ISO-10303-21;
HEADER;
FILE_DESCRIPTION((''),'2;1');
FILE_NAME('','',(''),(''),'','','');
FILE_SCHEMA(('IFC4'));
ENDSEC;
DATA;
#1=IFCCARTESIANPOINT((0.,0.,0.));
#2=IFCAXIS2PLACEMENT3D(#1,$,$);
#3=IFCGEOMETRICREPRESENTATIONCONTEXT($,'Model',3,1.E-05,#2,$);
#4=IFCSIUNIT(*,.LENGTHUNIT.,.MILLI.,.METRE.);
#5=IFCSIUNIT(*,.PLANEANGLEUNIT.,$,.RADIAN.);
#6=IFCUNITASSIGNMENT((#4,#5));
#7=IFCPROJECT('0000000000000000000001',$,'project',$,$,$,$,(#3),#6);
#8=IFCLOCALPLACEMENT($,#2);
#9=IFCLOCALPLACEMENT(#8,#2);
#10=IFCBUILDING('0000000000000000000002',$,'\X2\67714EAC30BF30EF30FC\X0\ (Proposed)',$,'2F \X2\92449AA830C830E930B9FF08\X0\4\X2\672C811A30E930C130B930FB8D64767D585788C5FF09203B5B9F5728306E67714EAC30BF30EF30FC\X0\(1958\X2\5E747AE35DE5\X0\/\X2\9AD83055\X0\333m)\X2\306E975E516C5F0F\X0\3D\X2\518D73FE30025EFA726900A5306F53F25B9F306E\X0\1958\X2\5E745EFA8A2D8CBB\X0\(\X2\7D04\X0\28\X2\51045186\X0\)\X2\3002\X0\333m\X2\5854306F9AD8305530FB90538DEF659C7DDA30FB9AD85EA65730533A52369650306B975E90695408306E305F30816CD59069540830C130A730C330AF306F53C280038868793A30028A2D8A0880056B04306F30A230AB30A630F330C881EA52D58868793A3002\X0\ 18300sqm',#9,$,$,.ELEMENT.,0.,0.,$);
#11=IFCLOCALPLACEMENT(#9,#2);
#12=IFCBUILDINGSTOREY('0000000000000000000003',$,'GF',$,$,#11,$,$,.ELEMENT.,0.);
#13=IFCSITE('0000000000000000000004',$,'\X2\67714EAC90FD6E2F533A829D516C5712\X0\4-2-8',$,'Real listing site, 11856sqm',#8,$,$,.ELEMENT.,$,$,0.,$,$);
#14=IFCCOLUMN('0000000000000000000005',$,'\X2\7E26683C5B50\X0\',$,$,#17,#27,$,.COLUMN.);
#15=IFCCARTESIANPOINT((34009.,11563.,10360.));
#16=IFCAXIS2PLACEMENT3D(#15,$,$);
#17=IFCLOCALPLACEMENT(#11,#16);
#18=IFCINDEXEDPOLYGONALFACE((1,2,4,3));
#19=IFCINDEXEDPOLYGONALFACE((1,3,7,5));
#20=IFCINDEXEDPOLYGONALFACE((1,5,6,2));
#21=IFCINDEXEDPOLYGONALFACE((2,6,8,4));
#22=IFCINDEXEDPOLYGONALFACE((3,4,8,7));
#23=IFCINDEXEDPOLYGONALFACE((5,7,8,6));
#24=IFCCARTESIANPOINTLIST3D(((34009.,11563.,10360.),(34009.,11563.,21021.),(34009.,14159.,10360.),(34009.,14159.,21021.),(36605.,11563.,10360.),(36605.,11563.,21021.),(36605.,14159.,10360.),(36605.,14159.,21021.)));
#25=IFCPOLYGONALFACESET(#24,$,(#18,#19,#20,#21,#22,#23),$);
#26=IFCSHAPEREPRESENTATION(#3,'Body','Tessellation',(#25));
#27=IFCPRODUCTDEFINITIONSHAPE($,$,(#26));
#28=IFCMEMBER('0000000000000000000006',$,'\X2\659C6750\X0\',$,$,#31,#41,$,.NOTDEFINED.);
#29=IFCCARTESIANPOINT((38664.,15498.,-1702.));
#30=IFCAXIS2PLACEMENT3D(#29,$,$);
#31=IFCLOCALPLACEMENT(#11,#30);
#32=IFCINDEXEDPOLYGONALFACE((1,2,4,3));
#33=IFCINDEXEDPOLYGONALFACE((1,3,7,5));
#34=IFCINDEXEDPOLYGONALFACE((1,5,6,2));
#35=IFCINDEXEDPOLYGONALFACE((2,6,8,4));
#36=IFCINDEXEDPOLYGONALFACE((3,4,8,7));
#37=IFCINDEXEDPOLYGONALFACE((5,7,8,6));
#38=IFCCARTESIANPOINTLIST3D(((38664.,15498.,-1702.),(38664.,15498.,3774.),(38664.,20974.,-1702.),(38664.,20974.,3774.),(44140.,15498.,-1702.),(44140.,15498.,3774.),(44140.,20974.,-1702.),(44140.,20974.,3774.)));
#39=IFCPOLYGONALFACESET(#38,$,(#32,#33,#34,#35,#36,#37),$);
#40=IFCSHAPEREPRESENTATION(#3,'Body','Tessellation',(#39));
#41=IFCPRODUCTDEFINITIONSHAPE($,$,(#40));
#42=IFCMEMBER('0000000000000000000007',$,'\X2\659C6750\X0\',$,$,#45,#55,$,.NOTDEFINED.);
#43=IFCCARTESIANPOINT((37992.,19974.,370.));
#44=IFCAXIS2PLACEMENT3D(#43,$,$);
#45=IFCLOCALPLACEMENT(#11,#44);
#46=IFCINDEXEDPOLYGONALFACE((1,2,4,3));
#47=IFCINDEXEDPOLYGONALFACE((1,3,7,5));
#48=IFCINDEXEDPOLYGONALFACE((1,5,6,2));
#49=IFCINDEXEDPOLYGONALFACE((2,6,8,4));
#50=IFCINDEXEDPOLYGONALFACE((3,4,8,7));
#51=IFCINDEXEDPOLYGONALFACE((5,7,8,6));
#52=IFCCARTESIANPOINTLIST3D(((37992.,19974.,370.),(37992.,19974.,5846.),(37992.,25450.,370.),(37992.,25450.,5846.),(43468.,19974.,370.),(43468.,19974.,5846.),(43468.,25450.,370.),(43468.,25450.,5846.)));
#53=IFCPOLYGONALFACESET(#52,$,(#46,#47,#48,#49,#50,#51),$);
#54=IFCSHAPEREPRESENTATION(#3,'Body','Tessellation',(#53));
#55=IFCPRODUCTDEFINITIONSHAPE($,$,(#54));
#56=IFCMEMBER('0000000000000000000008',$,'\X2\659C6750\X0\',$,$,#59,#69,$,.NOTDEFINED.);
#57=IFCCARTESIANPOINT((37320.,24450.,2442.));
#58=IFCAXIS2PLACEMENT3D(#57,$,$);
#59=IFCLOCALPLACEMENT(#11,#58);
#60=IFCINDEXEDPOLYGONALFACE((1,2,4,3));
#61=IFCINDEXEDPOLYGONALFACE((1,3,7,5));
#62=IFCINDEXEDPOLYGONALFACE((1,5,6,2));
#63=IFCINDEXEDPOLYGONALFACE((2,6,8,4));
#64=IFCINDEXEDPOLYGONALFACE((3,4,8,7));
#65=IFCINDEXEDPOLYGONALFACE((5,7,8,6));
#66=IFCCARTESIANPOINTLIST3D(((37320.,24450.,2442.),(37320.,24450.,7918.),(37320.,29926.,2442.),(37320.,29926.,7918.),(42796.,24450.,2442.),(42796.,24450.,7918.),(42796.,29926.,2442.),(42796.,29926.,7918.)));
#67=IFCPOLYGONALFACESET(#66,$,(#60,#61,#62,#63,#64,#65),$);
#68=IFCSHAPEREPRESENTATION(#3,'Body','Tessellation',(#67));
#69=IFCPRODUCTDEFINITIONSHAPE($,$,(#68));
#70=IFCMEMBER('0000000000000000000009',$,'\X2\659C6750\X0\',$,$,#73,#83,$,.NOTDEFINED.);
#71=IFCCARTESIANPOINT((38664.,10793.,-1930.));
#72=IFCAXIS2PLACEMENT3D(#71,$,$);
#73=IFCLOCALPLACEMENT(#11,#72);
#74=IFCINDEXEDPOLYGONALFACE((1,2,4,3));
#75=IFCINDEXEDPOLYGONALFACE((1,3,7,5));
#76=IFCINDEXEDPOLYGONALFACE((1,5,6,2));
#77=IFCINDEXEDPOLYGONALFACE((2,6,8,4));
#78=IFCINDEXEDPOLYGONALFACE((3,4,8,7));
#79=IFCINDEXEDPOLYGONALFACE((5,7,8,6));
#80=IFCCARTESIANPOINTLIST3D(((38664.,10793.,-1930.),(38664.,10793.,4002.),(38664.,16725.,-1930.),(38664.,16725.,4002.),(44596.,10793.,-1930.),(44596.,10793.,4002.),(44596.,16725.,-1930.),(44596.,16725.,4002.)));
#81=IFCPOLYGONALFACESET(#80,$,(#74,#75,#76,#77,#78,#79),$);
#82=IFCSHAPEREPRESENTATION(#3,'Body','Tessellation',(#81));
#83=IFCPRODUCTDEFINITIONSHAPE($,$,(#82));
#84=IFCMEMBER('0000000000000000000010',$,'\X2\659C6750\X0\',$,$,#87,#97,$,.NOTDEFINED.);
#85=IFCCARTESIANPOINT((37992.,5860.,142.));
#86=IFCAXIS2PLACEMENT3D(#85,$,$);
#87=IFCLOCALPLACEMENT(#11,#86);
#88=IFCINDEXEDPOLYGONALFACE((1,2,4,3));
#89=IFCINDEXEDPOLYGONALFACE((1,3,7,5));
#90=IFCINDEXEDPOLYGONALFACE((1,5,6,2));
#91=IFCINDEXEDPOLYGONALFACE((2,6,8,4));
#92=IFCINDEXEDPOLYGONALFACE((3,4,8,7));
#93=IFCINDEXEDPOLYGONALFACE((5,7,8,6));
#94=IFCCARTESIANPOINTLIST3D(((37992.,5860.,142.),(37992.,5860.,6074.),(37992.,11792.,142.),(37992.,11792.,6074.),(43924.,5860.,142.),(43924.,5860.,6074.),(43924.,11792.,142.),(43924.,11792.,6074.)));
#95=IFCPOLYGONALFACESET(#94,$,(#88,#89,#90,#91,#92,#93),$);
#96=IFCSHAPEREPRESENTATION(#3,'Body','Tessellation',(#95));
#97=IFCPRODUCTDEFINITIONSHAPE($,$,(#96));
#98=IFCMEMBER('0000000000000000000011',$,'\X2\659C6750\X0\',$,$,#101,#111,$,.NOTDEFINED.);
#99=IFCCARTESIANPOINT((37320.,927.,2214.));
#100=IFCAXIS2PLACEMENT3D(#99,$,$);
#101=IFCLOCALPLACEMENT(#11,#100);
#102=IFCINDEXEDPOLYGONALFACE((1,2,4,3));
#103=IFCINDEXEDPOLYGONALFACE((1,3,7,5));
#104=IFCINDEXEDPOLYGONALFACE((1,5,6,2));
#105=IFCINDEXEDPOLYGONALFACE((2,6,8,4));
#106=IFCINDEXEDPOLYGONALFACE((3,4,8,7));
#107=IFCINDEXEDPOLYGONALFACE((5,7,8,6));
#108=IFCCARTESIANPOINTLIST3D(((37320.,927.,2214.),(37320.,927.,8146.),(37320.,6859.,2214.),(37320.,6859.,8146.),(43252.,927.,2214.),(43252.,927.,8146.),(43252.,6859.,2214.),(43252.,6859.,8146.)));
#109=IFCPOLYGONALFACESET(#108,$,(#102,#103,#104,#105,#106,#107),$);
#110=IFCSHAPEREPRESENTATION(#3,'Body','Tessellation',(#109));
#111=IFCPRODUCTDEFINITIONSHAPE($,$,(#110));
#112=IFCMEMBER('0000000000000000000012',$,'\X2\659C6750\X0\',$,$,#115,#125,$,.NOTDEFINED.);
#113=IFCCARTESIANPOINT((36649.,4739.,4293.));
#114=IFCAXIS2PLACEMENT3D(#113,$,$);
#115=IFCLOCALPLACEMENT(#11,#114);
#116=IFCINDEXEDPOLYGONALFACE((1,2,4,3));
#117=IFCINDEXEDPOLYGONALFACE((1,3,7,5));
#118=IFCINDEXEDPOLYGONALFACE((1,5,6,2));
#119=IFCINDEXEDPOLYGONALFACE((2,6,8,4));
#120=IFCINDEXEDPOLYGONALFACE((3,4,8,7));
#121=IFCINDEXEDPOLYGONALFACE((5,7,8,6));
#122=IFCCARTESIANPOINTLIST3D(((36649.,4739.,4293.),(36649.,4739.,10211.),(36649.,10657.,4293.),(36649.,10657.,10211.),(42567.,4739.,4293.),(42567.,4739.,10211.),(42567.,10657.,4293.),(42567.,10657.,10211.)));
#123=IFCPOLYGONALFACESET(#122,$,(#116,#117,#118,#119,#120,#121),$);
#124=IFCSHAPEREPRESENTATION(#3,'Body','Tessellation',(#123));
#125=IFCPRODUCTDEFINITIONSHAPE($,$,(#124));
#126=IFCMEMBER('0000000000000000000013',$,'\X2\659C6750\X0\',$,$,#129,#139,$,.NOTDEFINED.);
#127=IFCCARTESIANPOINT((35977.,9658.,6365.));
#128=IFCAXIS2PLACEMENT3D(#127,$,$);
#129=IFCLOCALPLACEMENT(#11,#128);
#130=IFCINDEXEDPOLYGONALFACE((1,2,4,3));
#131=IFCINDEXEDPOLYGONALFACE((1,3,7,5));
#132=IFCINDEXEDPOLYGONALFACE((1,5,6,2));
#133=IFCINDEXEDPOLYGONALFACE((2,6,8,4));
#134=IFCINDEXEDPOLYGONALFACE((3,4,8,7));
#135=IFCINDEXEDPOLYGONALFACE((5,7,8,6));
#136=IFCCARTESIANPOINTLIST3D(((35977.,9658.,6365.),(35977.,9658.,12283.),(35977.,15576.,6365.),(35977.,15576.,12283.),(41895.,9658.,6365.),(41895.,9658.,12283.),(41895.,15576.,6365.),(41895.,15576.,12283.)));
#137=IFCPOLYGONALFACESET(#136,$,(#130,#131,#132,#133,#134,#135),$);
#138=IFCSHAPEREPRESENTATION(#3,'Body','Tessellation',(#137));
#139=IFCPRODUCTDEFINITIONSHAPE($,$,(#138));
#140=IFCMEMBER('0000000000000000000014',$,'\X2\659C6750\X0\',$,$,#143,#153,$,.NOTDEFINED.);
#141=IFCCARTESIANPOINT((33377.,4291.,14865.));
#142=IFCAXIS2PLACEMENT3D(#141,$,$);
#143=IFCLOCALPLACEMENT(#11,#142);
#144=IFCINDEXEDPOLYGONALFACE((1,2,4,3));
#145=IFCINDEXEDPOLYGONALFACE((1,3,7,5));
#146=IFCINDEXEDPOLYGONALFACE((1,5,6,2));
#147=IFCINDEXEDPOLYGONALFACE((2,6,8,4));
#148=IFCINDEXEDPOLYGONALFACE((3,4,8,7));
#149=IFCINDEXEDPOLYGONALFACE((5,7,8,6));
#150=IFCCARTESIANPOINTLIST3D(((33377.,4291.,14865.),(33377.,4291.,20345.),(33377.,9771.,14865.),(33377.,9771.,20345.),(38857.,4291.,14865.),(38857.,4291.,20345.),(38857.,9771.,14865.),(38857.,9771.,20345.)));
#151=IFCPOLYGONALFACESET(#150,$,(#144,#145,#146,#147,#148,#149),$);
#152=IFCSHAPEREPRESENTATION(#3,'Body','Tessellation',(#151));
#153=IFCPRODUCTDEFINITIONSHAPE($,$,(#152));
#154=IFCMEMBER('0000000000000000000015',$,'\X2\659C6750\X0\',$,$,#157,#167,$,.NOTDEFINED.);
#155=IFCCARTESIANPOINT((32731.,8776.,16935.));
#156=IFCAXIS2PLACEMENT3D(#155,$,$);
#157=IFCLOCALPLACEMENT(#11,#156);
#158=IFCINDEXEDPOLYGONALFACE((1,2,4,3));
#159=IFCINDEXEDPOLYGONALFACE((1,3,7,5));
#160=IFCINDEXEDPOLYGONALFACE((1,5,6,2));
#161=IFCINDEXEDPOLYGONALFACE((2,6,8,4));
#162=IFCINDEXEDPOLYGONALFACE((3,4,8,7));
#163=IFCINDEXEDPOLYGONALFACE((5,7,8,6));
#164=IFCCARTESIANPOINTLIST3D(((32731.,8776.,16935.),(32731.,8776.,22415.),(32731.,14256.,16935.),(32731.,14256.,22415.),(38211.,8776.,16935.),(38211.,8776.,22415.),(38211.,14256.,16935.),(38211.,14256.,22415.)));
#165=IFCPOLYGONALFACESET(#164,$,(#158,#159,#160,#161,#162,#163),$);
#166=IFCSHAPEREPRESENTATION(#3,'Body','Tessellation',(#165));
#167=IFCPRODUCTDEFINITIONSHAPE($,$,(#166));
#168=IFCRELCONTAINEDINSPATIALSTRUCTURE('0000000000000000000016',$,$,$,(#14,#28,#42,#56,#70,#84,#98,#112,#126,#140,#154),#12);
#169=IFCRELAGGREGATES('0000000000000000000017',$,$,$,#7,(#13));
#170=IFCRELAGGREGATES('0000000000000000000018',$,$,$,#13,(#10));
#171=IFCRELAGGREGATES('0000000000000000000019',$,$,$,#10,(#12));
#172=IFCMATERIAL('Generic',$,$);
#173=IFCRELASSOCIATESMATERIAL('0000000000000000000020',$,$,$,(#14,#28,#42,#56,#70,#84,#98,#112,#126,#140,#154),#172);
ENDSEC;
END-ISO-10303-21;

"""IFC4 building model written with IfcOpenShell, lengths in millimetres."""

from ifc_helpers import new_model, si_unit, frame, frame_2d, origin, place, context, project, spatial, rectangle, extrude, material, element, save


model = new_model("IFC4")

# Units and contexts
model_context = context("Model", 3, precision=1e-05, world=origin())
ifc_project = project(units=[si_unit("LENGTHUNIT", "METRE", prefix="MILLI"), si_unit("PLANEANGLEUNIT", "RADIAN")], contexts=[model_context])

# Site, building, storey
site_placement = place(None, origin())
site = spatial("IfcSite", under=ifc_project, at=site_placement, Name="東京都港区芝公園4-2-8", ObjectType="Real listing site, 11856sqm", CompositionType="ELEMENT", RefElevation=0.0)
building_placement = place(site_placement, origin())
building = spatial("IfcBuilding", under=site, at=building_placement, Name="東京タワー (Proposed)", ObjectType="2F 鉄骨トラス（4本脚ラチス・赤白塗装）※実在の東京タワー(1958年竣工/高さ333m)の非公式3D再現。建物¥は史実の1958年建設費(約28億円)。333m塔は高さ・道路斜線・高度地区制限に非適合のため法適合チェックは参考表示。設計者欄はアカウント自動表示。 18300sqm", CompositionType="ELEMENT", ElevationOfRefHeight=0.0, ElevationOfTerrain=0.0)
storey_placement = place(building_placement, origin())
storey = spatial("IfcBuildingStorey", under=building, at=storey_placement, Name="GF", CompositionType="ELEMENT", Elevation=0.0)

# Column
ifc_material = material(Name="Generic")
column_1_placement = place(storey_placement, frame((34009.0, 11563.0, 10360.0)))
element("IfcColumn", 1, at=column_1_placement, inside=storey, material=ifc_material, Name="縦格子", PredefinedType="COLUMN", context=model_context, shape_type="SweptSolid", body=[
    extrude(rectangle(XDim=2596.0, YDim=2596.0, at=frame_2d((1298.0, 1298.0))), frame((34009.0, 11563.0, 10360.0)), (0.0, 0.0, 1.0), 10661.0),
])

# Members
member_1_placement = place(storey_placement, frame((38664.0, 15498.0, -1702.0)))
element("IfcMember", 2, at=member_1_placement, inside=storey, material=ifc_material, Name="斜材", PredefinedType="NOTDEFINED", context=model_context, shape_type="SweptSolid", body=[
    extrude(rectangle(XDim=5476.0, YDim=5476.0, at=frame_2d((2738.0, 2738.0))), frame((38664.0, 15498.0, -1702.0)), (0.0, 0.0, 1.0), 5476.0),
])
member_2_placement = place(storey_placement, frame((37992.0, 19974.0, 370.0)))
element("IfcMember", 3, at=member_2_placement, inside=storey, material=ifc_material, Name="斜材", PredefinedType="NOTDEFINED", context=model_context, shape_type="SweptSolid", body=[
    extrude(rectangle(XDim=5476.0, YDim=5476.0, at=frame_2d((2738.0, 2738.0))), frame((37992.0, 19974.0, 370.0)), (0.0, 0.0, 1.0), 5476.0),
])
member_3_placement = place(storey_placement, frame((37320.0, 24450.0, 2442.0)))
element("IfcMember", 4, at=member_3_placement, inside=storey, material=ifc_material, Name="斜材", PredefinedType="NOTDEFINED", context=model_context, shape_type="SweptSolid", body=[
    extrude(rectangle(XDim=5476.0, YDim=5476.0, at=frame_2d((2738.0, 2738.0))), frame((37320.0, 24450.0, 2442.0)), (0.0, 0.0, 1.0), 5476.0),
])
member_4_placement = place(storey_placement, frame((38664.0, 10793.0, -1930.0)))
element("IfcMember", 5, at=member_4_placement, inside=storey, material=ifc_material, Name="斜材", PredefinedType="NOTDEFINED", context=model_context, shape_type="SweptSolid", body=[
    extrude(rectangle(XDim=5932.0, YDim=5932.0, at=frame_2d((2966.0, 2966.0))), frame((38664.0, 10793.0, -1930.0)), (0.0, 0.0, 1.0), 5932.0),
])
member_5_placement = place(storey_placement, frame((37992.0, 5860.0, 142.0)))
element("IfcMember", 6, at=member_5_placement, inside=storey, material=ifc_material, Name="斜材", PredefinedType="NOTDEFINED", context=model_context, shape_type="SweptSolid", body=[
    extrude(rectangle(XDim=5932.0, YDim=5932.0, at=frame_2d((2966.0, 2966.0))), frame((37992.0, 5860.0, 142.0)), (0.0, 0.0, 1.0), 5932.0),
])
member_6_placement = place(storey_placement, frame((37320.0, 927.0, 2214.0)))
element("IfcMember", 7, at=member_6_placement, inside=storey, material=ifc_material, Name="斜材", PredefinedType="NOTDEFINED", context=model_context, shape_type="SweptSolid", body=[
    extrude(rectangle(XDim=5932.0, YDim=5932.0, at=frame_2d((2966.0, 2966.0))), frame((37320.0, 927.0, 2214.0)), (0.0, 0.0, 1.0), 5932.0),
])
member_7_placement = place(storey_placement, frame((36649.0, 4739.0, 4293.0)))
element("IfcMember", 8, at=member_7_placement, inside=storey, material=ifc_material, Name="斜材", PredefinedType="NOTDEFINED", context=model_context, shape_type="SweptSolid", body=[
    extrude(rectangle(XDim=5918.0, YDim=5918.0, at=frame_2d((2959.0, 2959.0))), frame((36649.0, 4739.0, 4293.0)), (0.0, 0.0, 1.0), 5918.0),
])
member_8_placement = place(storey_placement, frame((35977.0, 9658.0, 6365.0)))
element("IfcMember", 9, at=member_8_placement, inside=storey, material=ifc_material, Name="斜材", PredefinedType="NOTDEFINED", context=model_context, shape_type="SweptSolid", body=[
    extrude(rectangle(XDim=5918.0, YDim=5918.0, at=frame_2d((2959.0, 2959.0))), frame((35977.0, 9658.0, 6365.0)), (0.0, 0.0, 1.0), 5918.0),
])
member_9_placement = place(storey_placement, frame((33377.0, 4291.0, 14865.0)))
element("IfcMember", 10, at=member_9_placement, inside=storey, material=ifc_material, Name="斜材", PredefinedType="NOTDEFINED", context=model_context, shape_type="SweptSolid", body=[
    extrude(rectangle(XDim=5480.0, YDim=5480.0, at=frame_2d((2740.0, 2740.0))), frame((33377.0, 4291.0, 14865.0)), (0.0, 0.0, 1.0), 5480.0),
])
member_10_placement = place(storey_placement, frame((32731.0, 8776.0, 16935.0)))
element("IfcMember", 11, at=member_10_placement, inside=storey, material=ifc_material, Name="斜材", PredefinedType="NOTDEFINED", context=model_context, shape_type="SweptSolid", body=[
    extrude(rectangle(XDim=5480.0, YDim=5480.0, at=frame_2d((2740.0, 2740.0))), frame((32731.0, 8776.0, 16935.0)), (0.0, 0.0, 1.0), 5480.0),
])

save(model, "model.ifc")
